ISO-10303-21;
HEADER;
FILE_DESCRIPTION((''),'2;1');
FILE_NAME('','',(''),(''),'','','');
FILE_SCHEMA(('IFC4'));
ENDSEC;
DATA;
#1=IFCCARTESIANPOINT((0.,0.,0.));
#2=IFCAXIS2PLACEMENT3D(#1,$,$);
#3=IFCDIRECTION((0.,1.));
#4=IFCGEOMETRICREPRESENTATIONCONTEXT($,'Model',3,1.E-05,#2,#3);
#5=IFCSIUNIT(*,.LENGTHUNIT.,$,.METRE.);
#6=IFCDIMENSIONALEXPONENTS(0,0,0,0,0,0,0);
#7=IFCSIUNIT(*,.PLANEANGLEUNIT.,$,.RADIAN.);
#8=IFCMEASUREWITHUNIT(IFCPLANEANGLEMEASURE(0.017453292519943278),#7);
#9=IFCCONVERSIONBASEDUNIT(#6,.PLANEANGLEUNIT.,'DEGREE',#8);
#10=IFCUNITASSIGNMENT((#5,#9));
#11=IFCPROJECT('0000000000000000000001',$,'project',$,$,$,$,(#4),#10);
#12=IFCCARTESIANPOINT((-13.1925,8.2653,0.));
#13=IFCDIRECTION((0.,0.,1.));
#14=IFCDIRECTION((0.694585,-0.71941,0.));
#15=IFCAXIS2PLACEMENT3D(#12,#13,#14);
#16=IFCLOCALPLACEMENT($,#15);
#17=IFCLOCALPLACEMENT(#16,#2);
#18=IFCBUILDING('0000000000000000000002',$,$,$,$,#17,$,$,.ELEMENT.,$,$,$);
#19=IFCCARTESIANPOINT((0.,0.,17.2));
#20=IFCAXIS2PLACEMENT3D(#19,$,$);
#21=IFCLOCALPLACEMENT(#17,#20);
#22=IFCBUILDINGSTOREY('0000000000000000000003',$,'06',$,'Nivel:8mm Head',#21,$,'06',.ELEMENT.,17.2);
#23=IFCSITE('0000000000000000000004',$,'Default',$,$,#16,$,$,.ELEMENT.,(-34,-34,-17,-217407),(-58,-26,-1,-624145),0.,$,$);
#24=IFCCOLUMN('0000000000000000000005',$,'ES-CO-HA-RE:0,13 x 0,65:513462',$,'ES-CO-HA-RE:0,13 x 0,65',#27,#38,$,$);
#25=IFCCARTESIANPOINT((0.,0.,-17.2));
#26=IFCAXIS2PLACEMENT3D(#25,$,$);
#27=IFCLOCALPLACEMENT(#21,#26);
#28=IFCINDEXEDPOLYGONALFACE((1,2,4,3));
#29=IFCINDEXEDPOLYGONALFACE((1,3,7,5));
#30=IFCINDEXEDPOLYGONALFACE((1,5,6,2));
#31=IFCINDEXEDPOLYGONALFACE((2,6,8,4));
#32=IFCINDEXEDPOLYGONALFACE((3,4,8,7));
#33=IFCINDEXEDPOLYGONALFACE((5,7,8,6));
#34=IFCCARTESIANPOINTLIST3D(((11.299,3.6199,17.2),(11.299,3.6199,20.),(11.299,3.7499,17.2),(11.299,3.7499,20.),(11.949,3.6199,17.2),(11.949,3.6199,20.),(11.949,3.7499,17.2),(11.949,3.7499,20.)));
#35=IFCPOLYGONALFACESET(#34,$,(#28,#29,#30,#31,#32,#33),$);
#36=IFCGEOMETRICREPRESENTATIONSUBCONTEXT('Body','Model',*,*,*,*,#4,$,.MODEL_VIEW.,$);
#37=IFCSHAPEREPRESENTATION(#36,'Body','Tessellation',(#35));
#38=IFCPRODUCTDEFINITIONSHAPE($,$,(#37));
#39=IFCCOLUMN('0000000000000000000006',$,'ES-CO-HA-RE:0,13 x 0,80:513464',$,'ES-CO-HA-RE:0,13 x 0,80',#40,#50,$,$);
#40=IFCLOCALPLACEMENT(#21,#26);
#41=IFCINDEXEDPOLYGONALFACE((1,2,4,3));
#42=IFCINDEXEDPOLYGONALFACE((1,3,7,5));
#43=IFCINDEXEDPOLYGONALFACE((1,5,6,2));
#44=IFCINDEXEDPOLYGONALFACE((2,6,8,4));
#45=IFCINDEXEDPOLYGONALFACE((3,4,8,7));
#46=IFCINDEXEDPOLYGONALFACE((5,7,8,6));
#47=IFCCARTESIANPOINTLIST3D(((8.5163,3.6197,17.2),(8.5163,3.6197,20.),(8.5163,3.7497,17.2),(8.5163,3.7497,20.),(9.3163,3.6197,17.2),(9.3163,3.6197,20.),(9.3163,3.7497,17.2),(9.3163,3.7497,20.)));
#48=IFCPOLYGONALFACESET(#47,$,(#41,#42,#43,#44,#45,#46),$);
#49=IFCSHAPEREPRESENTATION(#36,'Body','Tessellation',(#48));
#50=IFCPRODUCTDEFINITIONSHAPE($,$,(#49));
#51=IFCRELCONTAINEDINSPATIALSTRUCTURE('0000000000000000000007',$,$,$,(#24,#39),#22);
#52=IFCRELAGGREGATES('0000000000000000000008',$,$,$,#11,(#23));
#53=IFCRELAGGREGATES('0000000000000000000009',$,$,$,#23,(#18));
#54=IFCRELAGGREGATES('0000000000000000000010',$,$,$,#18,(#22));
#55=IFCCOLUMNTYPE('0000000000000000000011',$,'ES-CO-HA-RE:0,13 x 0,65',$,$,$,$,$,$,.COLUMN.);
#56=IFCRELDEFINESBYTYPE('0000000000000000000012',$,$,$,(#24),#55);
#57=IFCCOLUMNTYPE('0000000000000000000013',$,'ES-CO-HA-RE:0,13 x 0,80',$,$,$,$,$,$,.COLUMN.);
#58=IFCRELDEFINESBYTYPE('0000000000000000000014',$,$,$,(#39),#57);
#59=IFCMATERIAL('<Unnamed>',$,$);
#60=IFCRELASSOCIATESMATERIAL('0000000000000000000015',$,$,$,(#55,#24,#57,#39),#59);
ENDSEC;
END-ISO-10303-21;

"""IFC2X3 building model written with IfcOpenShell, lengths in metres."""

from ifc_helpers import new_model, entity, si_unit, converted_unit, direction, frame, frame_2d, origin, origin_2d_with_axis, place, context, subcontext, project, spatial, rectangle, extrude, source, transform, mapped, material, type_object, type_shapes, element, save


model = new_model("IFC2X3")

# Units and contexts
model_context = context("Model", 3, precision=1e-05, world=origin(), true_north=direction((0.0, 1.0)))
body_context = subcontext(model_context, "Body", "Model", "MODEL_VIEW")
ifc_project = project(units=[si_unit("LENGTHUNIT", "METRE"), converted_unit("PLANEANGLEUNIT", "DEGREE", entity("IfcPlaneAngleMeasure", 0.017453292519943278), si_unit("PLANEANGLEUNIT", "RADIAN"), dimensions=[0, 0, 0, 0, 0, 0, 0])], contexts=[model_context])

# Site, building, storey
site_placement = place(None, frame((-13.1925, 8.2653, 0.0), z_axis=(0.0, 0.0, 1.0), x_axis=(0.694585, -0.71941, 0.0)))
site = spatial("IfcSite", under=ifc_project, at=site_placement, Name="Default", CompositionType="ELEMENT", RefLatitude=(-34, -34, -17, -217407), RefLongitude=(-58, -26, -1, -624145), RefElevation=0.0)
building_placement = place(site_placement, origin())
building = spatial("IfcBuilding", under=site, at=building_placement, CompositionType="ELEMENT")
storey_placement = place(building_placement, frame((0.0, 0.0, 17.2)))
storey = spatial("IfcBuildingStorey", under=building, at=storey_placement, Name="06", ObjectType="Nivel:8mm Head", LongName="06", CompositionType="ELEMENT", Elevation=17.2)

# Columns
ifc_material_1 = material(Name="<Unnamed>")
column_type_1 = type_object("IfcColumnType", Name="ES-CO-HA-RE:0,13 x 0,65", PredefinedType="COLUMN", material=ifc_material_1)
shared_shape_1 = source(origin(), body_context, "Body", "SweptSolid", [
    extrude(rectangle(XDim=0.65, YDim=0.13, at=frame_2d((0.0, 0.0), x_axis=(1.0, 0.0))), frame((11.624, 3.6849, 17.2), z_axis=(0.0, 0.0, 1.0), x_axis=(-1.0, 0.0, 0.0)), (0.0, 0.0, 1.0), 2.8),
])
type_shapes(column_type_1, [shared_shape_1])
column_1_placement = place(storey_placement, frame((0.0, 0.0, -17.2)))
element("IfcColumn", 1, at=column_1_placement, inside=storey, type_object=column_type_1, material=ifc_material_1, Name="ES-CO-HA-RE:0,13 x 0,65:513462", ObjectType="ES-CO-HA-RE:0,13 x 0,65", context=body_context, shape_type="MappedRepresentation", body=[
    mapped(shared_shape_1, transform((0.0, 0.0, 0.0), scale=1.0)),
])
column_type_2 = type_object("IfcColumnType", Name="ES-CO-HA-RE:0,13 x 0,80", PredefinedType="COLUMN", material=ifc_material_1)
shared_shape_2 = source(origin(), body_context, "Body", "SweptSolid", [
    extrude(rectangle(XDim=0.8, YDim=0.13, at=origin_2d_with_axis()), frame((8.9163, 3.6847, 17.2), z_axis=(0.0, 0.0, 1.0), x_axis=(-1.0, 0.0, 0.0)), (0.0, 0.0, 1.0), 2.8),
])
type_shapes(column_type_2, [shared_shape_2])
column_2_placement = place(storey_placement, frame((0.0, 0.0, -17.2)))
element("IfcColumn", 2, at=column_2_placement, inside=storey, type_object=column_type_2, material=ifc_material_1, Name="ES-CO-HA-RE:0,13 x 0,80:513464", ObjectType="ES-CO-HA-RE:0,13 x 0,80", context=body_context, shape_type="MappedRepresentation", body=[
    mapped(shared_shape_2, transform((0.0, 0.0, 0.0), scale=1.0)),
])

save(model, "model.ifc")
